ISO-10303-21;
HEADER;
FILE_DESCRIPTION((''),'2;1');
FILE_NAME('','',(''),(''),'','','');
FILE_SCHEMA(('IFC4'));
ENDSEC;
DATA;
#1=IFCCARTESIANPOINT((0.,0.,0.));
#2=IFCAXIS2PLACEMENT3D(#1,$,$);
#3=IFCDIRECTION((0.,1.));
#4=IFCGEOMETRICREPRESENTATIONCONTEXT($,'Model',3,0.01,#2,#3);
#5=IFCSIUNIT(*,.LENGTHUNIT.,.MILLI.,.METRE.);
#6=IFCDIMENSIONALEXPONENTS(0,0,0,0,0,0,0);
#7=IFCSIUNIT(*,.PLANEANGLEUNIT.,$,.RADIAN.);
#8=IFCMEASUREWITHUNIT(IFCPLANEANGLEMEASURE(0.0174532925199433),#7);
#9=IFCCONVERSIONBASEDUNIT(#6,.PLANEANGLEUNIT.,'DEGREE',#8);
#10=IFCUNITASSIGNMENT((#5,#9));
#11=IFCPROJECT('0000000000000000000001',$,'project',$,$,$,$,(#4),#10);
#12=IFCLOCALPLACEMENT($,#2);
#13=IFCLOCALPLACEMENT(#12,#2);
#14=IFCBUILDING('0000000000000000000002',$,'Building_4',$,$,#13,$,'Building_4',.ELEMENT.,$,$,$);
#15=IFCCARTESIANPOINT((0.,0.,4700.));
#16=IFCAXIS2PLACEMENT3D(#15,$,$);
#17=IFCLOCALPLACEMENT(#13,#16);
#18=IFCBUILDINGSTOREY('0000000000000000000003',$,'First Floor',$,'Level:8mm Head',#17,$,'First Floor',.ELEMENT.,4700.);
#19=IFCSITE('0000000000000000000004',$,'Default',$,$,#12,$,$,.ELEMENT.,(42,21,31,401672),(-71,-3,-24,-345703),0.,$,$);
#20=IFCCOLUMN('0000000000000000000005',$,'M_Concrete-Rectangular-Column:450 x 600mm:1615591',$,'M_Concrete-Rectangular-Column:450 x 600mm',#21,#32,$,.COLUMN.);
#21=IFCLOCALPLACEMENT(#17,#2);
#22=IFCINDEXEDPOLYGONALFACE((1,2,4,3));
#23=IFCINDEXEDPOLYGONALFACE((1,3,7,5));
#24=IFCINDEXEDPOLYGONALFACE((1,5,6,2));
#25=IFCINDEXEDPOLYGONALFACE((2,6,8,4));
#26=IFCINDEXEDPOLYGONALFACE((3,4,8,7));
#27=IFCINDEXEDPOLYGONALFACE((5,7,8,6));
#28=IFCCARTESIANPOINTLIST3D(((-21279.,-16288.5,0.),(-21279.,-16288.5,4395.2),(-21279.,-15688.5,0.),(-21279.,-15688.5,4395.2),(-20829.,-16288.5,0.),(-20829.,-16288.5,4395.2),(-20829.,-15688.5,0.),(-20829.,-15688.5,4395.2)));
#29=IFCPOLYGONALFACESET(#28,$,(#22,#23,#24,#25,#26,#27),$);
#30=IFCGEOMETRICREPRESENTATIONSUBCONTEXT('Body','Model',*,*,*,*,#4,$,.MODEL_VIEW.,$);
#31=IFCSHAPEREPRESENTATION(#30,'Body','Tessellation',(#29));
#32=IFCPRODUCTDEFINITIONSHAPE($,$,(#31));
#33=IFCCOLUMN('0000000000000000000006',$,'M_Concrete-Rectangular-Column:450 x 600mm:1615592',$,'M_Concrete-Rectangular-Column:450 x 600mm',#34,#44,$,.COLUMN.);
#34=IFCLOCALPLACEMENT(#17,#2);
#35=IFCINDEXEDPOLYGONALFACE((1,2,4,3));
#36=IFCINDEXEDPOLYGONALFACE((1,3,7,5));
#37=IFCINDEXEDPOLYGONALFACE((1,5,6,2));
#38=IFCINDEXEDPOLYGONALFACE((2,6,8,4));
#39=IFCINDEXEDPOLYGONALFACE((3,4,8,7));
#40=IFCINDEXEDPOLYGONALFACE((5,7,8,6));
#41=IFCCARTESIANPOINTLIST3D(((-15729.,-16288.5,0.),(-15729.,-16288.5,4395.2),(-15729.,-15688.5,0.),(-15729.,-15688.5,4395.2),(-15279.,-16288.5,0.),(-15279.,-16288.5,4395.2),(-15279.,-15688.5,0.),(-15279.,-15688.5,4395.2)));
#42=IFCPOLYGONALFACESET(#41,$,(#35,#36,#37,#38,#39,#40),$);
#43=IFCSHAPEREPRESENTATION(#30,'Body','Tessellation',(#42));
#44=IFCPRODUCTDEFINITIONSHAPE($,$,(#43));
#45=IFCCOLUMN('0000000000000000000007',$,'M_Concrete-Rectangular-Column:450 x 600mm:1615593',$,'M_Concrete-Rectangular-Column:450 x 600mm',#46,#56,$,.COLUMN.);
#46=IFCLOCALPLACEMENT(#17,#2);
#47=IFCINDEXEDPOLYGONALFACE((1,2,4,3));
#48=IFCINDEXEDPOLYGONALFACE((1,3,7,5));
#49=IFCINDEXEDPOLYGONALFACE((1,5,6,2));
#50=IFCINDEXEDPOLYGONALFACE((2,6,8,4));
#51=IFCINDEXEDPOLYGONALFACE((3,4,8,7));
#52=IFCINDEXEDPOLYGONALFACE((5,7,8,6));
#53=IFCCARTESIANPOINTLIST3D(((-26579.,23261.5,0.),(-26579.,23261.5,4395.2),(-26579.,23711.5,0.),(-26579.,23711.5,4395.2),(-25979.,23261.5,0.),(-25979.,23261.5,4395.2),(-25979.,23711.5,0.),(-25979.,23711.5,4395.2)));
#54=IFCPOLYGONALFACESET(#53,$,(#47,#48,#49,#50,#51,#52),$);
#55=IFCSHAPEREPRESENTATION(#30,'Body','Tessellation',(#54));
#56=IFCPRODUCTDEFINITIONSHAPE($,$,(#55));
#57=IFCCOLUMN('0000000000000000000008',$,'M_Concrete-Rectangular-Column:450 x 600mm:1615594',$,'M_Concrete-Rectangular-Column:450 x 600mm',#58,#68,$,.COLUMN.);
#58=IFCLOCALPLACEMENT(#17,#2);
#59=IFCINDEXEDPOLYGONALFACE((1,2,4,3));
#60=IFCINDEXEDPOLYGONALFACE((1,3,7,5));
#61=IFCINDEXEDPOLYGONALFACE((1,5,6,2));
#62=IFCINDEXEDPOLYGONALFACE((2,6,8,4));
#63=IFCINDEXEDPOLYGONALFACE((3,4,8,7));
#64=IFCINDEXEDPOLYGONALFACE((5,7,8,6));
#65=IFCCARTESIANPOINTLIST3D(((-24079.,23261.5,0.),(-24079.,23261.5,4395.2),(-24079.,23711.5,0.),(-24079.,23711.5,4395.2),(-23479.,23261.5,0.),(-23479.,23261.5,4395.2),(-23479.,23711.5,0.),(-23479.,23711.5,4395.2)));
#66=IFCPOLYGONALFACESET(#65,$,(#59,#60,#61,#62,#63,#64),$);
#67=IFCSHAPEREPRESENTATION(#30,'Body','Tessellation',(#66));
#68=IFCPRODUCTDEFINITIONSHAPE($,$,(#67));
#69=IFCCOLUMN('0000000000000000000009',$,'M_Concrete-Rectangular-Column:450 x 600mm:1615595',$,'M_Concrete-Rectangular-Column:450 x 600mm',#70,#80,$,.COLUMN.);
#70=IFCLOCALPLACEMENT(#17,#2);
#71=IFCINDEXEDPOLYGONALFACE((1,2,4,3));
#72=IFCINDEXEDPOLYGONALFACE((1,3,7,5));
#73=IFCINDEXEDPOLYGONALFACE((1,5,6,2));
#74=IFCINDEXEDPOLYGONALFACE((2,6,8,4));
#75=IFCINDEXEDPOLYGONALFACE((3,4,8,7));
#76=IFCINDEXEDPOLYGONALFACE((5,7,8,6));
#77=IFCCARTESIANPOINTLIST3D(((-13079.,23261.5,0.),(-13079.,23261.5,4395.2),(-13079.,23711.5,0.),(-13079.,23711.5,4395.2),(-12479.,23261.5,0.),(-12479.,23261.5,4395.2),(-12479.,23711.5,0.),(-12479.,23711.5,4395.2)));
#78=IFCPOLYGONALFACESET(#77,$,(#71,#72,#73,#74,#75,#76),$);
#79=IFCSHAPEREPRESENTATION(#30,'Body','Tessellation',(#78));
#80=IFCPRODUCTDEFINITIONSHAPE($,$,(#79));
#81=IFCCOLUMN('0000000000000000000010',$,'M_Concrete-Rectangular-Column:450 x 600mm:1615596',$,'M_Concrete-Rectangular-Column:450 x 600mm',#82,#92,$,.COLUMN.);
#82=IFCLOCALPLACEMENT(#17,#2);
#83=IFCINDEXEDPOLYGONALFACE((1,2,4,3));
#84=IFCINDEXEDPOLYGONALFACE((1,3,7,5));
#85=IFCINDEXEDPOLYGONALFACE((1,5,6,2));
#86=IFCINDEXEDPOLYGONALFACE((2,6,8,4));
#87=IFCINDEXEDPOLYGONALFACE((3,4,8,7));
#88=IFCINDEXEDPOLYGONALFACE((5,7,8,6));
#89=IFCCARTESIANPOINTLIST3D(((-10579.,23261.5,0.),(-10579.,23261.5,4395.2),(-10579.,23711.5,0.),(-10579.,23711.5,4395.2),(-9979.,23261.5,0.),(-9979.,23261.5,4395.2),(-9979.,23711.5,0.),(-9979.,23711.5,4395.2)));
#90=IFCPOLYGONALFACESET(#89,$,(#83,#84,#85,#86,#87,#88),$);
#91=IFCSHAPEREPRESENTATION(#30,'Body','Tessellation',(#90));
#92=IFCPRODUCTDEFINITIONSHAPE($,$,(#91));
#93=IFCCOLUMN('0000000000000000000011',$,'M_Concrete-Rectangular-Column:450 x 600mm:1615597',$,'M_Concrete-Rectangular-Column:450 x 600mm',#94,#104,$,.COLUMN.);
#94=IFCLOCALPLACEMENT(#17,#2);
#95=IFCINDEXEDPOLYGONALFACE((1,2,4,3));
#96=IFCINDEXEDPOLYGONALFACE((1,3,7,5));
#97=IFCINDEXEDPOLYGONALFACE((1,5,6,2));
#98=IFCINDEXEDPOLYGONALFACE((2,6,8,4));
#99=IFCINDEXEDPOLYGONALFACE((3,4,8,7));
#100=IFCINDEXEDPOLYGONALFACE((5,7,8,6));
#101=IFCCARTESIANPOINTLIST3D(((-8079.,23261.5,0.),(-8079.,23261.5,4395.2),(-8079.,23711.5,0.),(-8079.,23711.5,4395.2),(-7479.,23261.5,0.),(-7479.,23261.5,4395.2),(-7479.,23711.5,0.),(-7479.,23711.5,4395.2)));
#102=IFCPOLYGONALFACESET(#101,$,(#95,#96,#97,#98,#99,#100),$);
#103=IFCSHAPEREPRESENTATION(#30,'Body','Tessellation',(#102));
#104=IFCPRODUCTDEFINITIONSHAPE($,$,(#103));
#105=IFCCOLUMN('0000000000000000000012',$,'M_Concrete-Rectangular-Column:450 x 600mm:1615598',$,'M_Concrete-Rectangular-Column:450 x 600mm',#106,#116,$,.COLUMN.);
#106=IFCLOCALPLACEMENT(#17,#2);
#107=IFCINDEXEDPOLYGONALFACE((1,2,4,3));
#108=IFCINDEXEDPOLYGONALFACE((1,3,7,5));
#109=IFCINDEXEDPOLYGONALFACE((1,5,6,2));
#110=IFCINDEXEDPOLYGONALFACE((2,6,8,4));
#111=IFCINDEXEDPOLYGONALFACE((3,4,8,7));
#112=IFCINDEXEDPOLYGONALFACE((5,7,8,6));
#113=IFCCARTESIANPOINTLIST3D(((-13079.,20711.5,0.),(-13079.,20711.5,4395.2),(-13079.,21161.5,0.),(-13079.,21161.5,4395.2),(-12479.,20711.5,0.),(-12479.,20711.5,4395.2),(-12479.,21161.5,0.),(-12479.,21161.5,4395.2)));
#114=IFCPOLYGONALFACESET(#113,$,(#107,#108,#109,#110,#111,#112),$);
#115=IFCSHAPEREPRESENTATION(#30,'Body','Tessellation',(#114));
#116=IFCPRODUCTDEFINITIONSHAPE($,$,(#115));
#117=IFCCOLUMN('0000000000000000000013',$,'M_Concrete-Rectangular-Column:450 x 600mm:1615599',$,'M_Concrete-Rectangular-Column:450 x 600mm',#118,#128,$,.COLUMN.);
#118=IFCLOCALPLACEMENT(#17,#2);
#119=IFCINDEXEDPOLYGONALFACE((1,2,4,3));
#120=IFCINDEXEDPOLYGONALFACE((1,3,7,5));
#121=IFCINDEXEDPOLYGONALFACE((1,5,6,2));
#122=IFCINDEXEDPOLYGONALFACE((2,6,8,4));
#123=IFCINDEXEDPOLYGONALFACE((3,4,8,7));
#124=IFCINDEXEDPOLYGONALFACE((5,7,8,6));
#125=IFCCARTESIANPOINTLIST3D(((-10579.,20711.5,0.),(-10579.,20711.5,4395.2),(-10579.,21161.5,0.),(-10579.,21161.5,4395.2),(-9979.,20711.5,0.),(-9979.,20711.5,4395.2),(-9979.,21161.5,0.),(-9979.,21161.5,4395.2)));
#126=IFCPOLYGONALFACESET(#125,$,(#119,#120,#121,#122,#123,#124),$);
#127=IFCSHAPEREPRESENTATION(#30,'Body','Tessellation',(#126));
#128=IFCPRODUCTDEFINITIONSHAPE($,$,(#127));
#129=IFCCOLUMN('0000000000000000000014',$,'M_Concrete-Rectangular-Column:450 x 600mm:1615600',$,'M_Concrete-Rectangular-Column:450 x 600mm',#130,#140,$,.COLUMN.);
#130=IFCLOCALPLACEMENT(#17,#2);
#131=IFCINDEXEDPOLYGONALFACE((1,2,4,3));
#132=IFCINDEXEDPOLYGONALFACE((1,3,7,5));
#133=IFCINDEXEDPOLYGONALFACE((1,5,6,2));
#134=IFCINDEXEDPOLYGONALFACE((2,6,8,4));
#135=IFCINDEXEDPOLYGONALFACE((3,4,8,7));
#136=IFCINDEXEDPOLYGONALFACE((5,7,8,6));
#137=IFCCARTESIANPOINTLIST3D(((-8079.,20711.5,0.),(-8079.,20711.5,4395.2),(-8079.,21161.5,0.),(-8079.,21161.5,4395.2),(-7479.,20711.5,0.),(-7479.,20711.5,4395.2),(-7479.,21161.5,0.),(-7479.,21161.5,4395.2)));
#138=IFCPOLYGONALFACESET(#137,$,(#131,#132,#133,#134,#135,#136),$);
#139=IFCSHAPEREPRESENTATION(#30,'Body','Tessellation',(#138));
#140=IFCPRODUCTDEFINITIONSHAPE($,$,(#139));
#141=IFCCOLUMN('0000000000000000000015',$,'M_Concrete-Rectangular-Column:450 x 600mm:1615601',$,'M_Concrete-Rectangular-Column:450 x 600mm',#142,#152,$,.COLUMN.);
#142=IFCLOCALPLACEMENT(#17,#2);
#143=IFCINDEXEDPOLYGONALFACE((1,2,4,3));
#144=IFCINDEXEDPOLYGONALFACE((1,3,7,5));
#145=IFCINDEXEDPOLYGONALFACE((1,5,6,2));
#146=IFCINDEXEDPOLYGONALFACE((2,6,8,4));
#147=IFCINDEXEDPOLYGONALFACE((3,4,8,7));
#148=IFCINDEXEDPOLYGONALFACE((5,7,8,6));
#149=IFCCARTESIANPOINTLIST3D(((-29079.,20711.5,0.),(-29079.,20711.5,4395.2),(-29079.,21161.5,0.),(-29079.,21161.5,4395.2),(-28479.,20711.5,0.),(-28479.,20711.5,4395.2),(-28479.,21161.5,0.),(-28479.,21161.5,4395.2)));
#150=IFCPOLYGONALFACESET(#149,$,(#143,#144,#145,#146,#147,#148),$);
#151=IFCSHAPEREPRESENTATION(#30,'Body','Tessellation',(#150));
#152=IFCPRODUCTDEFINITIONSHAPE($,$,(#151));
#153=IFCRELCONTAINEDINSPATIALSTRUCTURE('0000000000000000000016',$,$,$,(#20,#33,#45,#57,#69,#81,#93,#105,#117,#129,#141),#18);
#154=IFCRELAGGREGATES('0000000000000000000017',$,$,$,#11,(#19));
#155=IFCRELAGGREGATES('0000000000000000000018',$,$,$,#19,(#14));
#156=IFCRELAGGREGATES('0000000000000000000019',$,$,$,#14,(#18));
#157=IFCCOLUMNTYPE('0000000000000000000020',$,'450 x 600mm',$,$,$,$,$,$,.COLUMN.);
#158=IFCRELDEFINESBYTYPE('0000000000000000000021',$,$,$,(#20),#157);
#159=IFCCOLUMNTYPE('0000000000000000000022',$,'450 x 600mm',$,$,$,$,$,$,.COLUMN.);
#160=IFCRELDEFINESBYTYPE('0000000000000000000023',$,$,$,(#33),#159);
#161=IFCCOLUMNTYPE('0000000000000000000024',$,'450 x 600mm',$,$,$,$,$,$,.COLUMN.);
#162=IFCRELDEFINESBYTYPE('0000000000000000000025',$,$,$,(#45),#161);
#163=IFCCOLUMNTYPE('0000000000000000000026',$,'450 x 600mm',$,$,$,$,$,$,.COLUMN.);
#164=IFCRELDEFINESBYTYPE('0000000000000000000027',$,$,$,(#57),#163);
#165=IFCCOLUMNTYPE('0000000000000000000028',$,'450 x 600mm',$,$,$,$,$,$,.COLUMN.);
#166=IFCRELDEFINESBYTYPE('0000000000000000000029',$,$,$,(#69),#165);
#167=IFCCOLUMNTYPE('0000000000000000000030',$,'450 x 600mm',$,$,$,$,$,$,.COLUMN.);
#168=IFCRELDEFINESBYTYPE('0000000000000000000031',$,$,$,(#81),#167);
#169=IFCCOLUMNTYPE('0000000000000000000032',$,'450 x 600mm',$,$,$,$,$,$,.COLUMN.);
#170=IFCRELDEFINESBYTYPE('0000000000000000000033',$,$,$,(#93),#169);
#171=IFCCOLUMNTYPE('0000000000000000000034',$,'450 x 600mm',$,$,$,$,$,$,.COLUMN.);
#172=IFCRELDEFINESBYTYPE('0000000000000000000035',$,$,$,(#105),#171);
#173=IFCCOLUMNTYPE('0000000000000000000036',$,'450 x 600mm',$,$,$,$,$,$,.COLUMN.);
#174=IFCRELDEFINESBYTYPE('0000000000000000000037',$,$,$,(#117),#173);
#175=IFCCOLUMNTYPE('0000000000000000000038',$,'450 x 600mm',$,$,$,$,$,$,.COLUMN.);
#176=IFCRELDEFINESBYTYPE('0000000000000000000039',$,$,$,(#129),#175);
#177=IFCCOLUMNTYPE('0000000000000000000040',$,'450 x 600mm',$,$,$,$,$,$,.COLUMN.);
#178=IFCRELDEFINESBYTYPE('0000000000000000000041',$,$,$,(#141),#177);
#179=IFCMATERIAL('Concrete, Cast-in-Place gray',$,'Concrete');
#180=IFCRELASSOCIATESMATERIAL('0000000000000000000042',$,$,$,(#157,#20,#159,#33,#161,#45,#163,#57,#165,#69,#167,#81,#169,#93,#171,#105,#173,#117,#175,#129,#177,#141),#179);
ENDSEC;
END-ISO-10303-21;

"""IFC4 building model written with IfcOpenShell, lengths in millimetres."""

from ifc_helpers import new_model, entity, si_unit, converted_unit, direction, frame, origin, place, context, subcontext, project, spatial, indexed_curve, outline, extrude, source, transform, mapped, material, type_object, type_shapes, element, save


model = new_model("IFC4")

# Units and contexts
model_context = context("Model", 3, precision=0.01, world=origin(), true_north=direction((0.0, 1.0)))
body_context = subcontext(model_context, "Body", "Model", "MODEL_VIEW")
ifc_project = project(units=[si_unit("LENGTHUNIT", "METRE", prefix="MILLI"), converted_unit("PLANEANGLEUNIT", "DEGREE", entity("IfcPlaneAngleMeasure", 0.0174532925199433), si_unit("PLANEANGLEUNIT", "RADIAN"), dimensions=[0, 0, 0, 0, 0, 0, 0])], contexts=[model_context])

# Site, building, storey
site_placement = place(None, origin())
site = spatial("IfcSite", under=ifc_project, at=site_placement, Name="Default", CompositionType="ELEMENT", RefLatitude=(42, 21, 31, 401672), RefLongitude=(-71, -3, -24, -345703), RefElevation=0.0)
building_placement = place(site_placement, origin())
building = spatial("IfcBuilding", under=site, at=building_placement, Name="Building_4", LongName="Building_4", CompositionType="ELEMENT")
storey_placement = place(building_placement, frame((0.0, 0.0, 4700.0)))
storey = spatial("IfcBuildingStorey", under=building, at=storey_placement, Name="First Floor", ObjectType="Level:8mm Head", LongName="First Floor", CompositionType="ELEMENT", Elevation=4700.0)

# Columns
ifc_material = material(Name="Concrete, Cast-in-Place gray", Category="Concrete")
column_type_1 = type_object("IfcColumnType", Name="450 x 600mm", PredefinedType="COLUMN", material=ifc_material)
shared_shape_1 = source(origin(), body_context, "Body", "SweptSolid", [
    extrude(outline(indexed_curve([(-2197.6, -300.0), (2197.6, -300.0), (2197.6, 300.0), (-2197.6, 300.0), (-2197.6, -300.0)], self_intersect=False)), frame((-21279.0, -15988.5, 6897.6), z_axis=(1.0, 0.0, 0.0), x_axis=(0.0, 0.0, 1.0)), (0.0, 0.0, 1.0), 450.0),
])
type_shapes(column_type_1, [shared_shape_1])
column_1_placement = place(storey_placement, frame((0.0, 0.0, -4700.0)))
element("IfcColumn", 1, at=column_1_placement, inside=storey, type_object=column_type_1, material=ifc_material, Name="M_Concrete-Rectangular-Column:450 x 600mm:1615591", ObjectType="M_Concrete-Rectangular-Column:450 x 600mm", PredefinedType="COLUMN", context=body_context, shape_type="MappedRepresentation", body=[
    mapped(shared_shape_1, transform((0.0, 0.0, 0.0), scale=1.0)),
])
column_type_2 = type_object("IfcColumnType", Name="450 x 600mm", PredefinedType="COLUMN", material=ifc_material)
shared_shape_2 = source(origin(), body_context, "Body", "SweptSolid", [
    extrude(outline(indexed_curve([(-2197.6, -300.0), (2197.6, -300.0), (2197.6, 300.0), (-2197.6, 300.0), (-2197.6, -300.0)], self_intersect=False)), frame((-15729.0, -15988.5, 6897.6), z_axis=(1.0, 0.0, 0.0), x_axis=(0.0, 0.0, 1.0)), (0.0, 0.0, 1.0), 450.0),
])
type_shapes(column_type_2, [shared_shape_2])
column_2_placement = place(storey_placement, frame((0.0, 0.0, -4700.0)))
element("IfcColumn", 2, at=column_2_placement, inside=storey, type_object=column_type_2, material=ifc_material, Name="M_Concrete-Rectangular-Column:450 x 600mm:1615592", ObjectType="M_Concrete-Rectangular-Column:450 x 600mm", PredefinedType="COLUMN", context=body_context, shape_type="MappedRepresentation", body=[
    mapped(shared_shape_2, transform((0.0, 0.0, 0.0), scale=1.0)),
])
column_type_3 = type_object("IfcColumnType", Name="450 x 600mm", PredefinedType="COLUMN", material=ifc_material)
shared_shape_3 = source(origin(), body_context, "Body", "SweptSolid", [
    extrude(outline(indexed_curve([(-225.0, -300.0), (225.0, -300.0), (225.0, 300.0), (-225.0, 300.0), (-225.0, -300.0)], self_intersect=False)), frame((-26279.0, 23486.5, 4700.0), z_axis=(0.0, 0.0, 1.0), x_axis=(0.0, -1.0, 0.0)), (0.0, 0.0, 1.0), 4395.2),
])
type_shapes(column_type_3, [shared_shape_3])
column_3_placement = place(storey_placement, frame((0.0, 0.0, -4700.0)))
element("IfcColumn", 3, at=column_3_placement, inside=storey, type_object=column_type_3, material=ifc_material, Name="M_Concrete-Rectangular-Column:450 x 600mm:1615593", ObjectType="M_Concrete-Rectangular-Column:450 x 600mm", PredefinedType="COLUMN", context=body_context, shape_type="MappedRepresentation", body=[
    mapped(shared_shape_3, transform((0.0, 0.0, 0.0), scale=1.0)),
])
column_type_4 = type_object("IfcColumnType", Name="450 x 600mm", PredefinedType="COLUMN", material=ifc_material)
shared_shape_4 = source(origin(), body_context, "Body", "SweptSolid", [
    extrude(outline(indexed_curve([(-225.0, -300.0), (225.0, -300.0), (225.0, 300.0), (-225.0, 300.0), (-225.0, -300.0)], self_intersect=False)), frame((-23779.0, 23486.5, 4700.0), z_axis=(0.0, 0.0, 1.0), x_axis=(0.0, -1.0, 0.0)), (0.0, 0.0, 1.0), 4395.2),
])
type_shapes(column_type_4, [shared_shape_4])
column_4_placement = place(storey_placement, frame((0.0, 0.0, -4700.0)))
element("IfcColumn", 4, at=column_4_placement, inside=storey, type_object=column_type_4, material=ifc_material, Name="M_Concrete-Rectangular-Column:450 x 600mm:1615594", ObjectType="M_Concrete-Rectangular-Column:450 x 600mm", PredefinedType="COLUMN", context=body_context, shape_type="MappedRepresentation", body=[
    mapped(shared_shape_4, transform((0.0, 0.0, 0.0), scale=1.0)),
])
column_type_5 = type_object("IfcColumnType", Name="450 x 600mm", PredefinedType="COLUMN", material=ifc_material)
shared_shape_5 = source(origin(), body_context, "Body", "SweptSolid", [
    extrude(outline(indexed_curve([(-2197.6, -225.0), (2197.6, -225.0), (2197.6, 225.0), (-2197.6, 225.0), (-2197.6, -225.0)], self_intersect=False)), frame((-13079.0, 23486.5, 6897.6), z_axis=(1.0, 0.0, 0.0), x_axis=(0.0, 0.0, 1.0)), (0.0, 0.0, 1.0), 600.0),
])
type_shapes(column_type_5, [shared_shape_5])
column_5_placement = place(storey_placement, frame((0.0, 0.0, -4700.0)))
element("IfcColumn", 5, at=column_5_placement, inside=storey, type_object=column_type_5, material=ifc_material, Name="M_Concrete-Rectangular-Column:450 x 600mm:1615595", ObjectType="M_Concrete-Rectangular-Column:450 x 600mm", PredefinedType="COLUMN", context=body_context, shape_type="MappedRepresentation", body=[
    mapped(shared_shape_5, transform((0.0, 0.0, 0.0), scale=1.0)),
])
column_type_6 = type_object("IfcColumnType", Name="450 x 600mm", PredefinedType="COLUMN", material=ifc_material)
shared_shape_6 = source(origin(), body_context, "Body", "SweptSolid", [
    extrude(outline(indexed_curve([(-225.0, -300.0), (225.0, -300.0), (225.0, 300.0), (-225.0, 300.0), (-225.0, -300.0)], self_intersect=False)), frame((-10279.0, 23486.5, 4700.0), z_axis=(0.0, 0.0, 1.0), x_axis=(0.0, -1.0, 0.0)), (0.0, 0.0, 1.0), 4395.2),
])
type_shapes(column_type_6, [shared_shape_6])
column_6_placement = place(storey_placement, frame((0.0, 0.0, -4700.0)))
element("IfcColumn", 6, at=column_6_placement, inside=storey, type_object=column_type_6, material=ifc_material, Name="M_Concrete-Rectangular-Column:450 x 600mm:1615596", ObjectType="M_Concrete-Rectangular-Column:450 x 600mm", PredefinedType="COLUMN", context=body_context, shape_type="MappedRepresentation", body=[
    mapped(shared_shape_6, transform((0.0, 0.0, 0.0), scale=1.0)),
])
column_type_7 = type_object("IfcColumnType", Name="450 x 600mm", PredefinedType="COLUMN", material=ifc_material)
shared_shape_7 = source(origin(), body_context, "Body", "SweptSolid", [
    extrude(outline(indexed_curve([(-225.0, -300.0), (225.0, -300.0), (225.0, 300.0), (-225.0, 300.0), (-225.0, -300.0)], self_intersect=False)), frame((-7779.0, 23486.5, 4700.0), z_axis=(0.0, 0.0, 1.0), x_axis=(0.0, -1.0, 0.0)), (0.0, 0.0, 1.0), 4395.2),
])
type_shapes(column_type_7, [shared_shape_7])
column_7_placement = place(storey_placement, frame((0.0, 0.0, -4700.0)))
element("IfcColumn", 7, at=column_7_placement, inside=storey, type_object=column_type_7, material=ifc_material, Name="M_Concrete-Rectangular-Column:450 x 600mm:1615597", ObjectType="M_Concrete-Rectangular-Column:450 x 600mm", PredefinedType="COLUMN", context=body_context, shape_type="MappedRepresentation", body=[
    mapped(shared_shape_7, transform((0.0, 0.0, 0.0), scale=1.0)),
])
column_type_8 = type_object("IfcColumnType", Name="450 x 600mm", PredefinedType="COLUMN", material=ifc_material)
shared_shape_8 = source(origin(), body_context, "Body", "SweptSolid", [
    extrude(outline(indexed_curve([(-2197.6, -225.0), (2197.6, -225.0), (2197.6, 225.0), (-2197.6, 225.0), (-2197.6, -225.0)], self_intersect=False)), frame((-13079.0, 20936.5, 6897.6), z_axis=(1.0, 0.0, 0.0), x_axis=(0.0, 0.0, 1.0)), (0.0, 0.0, 1.0), 600.0),
])
type_shapes(column_type_8, [shared_shape_8])
column_8_placement = place(storey_placement, frame((0.0, 0.0, -4700.0)))
element("IfcColumn", 8, at=column_8_placement, inside=storey, type_object=column_type_8, material=ifc_material, Name="M_Concrete-Rectangular-Column:450 x 600mm:1615598", ObjectType="M_Concrete-Rectangular-Column:450 x 600mm", PredefinedType="COLUMN", context=body_context, shape_type="MappedRepresentation", body=[
    mapped(shared_shape_8, transform((0.0, 0.0, 0.0), scale=1.0)),
])
column_type_9 = type_object("IfcColumnType", Name="450 x 600mm", PredefinedType="COLUMN", material=ifc_material)
shared_shape_9 = source(origin(), body_context, "Body", "SweptSolid", [
    extrude(outline(indexed_curve([(-225.0, -300.0), (225.0, -300.0), (225.0, 300.0), (-225.0, 300.0), (-225.0, -300.0)], self_intersect=False)), frame((-10279.0, 20936.5, 4700.0), z_axis=(0.0, 0.0, 1.0), x_axis=(0.0, -1.0, 0.0)), (0.0, 0.0, 1.0), 4395.2),
])
type_shapes(column_type_9, [shared_shape_9])
column_9_placement = place(storey_placement, frame((0.0, 0.0, -4700.0)))
element("IfcColumn", 9, at=column_9_placement, inside=storey, type_object=column_type_9, material=ifc_material, Name="M_Concrete-Rectangular-Column:450 x 600mm:1615599", ObjectType="M_Concrete-Rectangular-Column:450 x 600mm", PredefinedType="COLUMN", context=body_context, shape_type="MappedRepresentation", body=[
    mapped(shared_shape_9, transform((0.0, 0.0, 0.0), scale=1.0)),
])
column_type_10 = type_object("IfcColumnType", Name="450 x 600mm", PredefinedType="COLUMN", material=ifc_material)
shared_shape_10 = source(origin(), body_context, "Body", "SweptSolid", [
    extrude(outline(indexed_curve([(-225.0, -300.0), (225.0, -300.0), (225.0, 300.0), (-225.0, 300.0), (-225.0, -300.0)], self_intersect=False)), frame((-7779.0, 20936.5, 4700.0), z_axis=(0.0, 0.0, 1.0), x_axis=(0.0, -1.0, 0.0)), (0.0, 0.0, 1.0), 4395.2),
])
type_shapes(column_type_10, [shared_shape_10])
column_10_placement = place(storey_placement, frame((0.0, 0.0, -4700.0)))
element("IfcColumn", 10, at=column_10_placement, inside=storey, type_object=column_type_10, material=ifc_material, Name="M_Concrete-Rectangular-Column:450 x 600mm:1615600", ObjectType="M_Concrete-Rectangular-Column:450 x 600mm", PredefinedType="COLUMN", context=body_context, shape_type="MappedRepresentation", body=[
    mapped(shared_shape_10, transform((0.0, 0.0, 0.0), scale=1.0)),
])
column_type_11 = type_object("IfcColumnType", Name="450 x 600mm", PredefinedType="COLUMN", material=ifc_material)
shared_shape_11 = source(origin(), body_context, "Body", "SweptSolid", [
    extrude(outline(indexed_curve([(-225.0, -300.0), (225.0, -300.0), (225.0, 300.0), (-225.0, 300.0), (-225.0, -300.0)], self_intersect=False)), frame((-28779.0, 20936.5, 4700.0), z_axis=(0.0, 0.0, 1.0), x_axis=(0.0, -1.0, 0.0)), (0.0, 0.0, 1.0), 4395.2),
])
type_shapes(column_type_11, [shared_shape_11])
column_11_placement = place(storey_placement, frame((0.0, 0.0, -4700.0)))
element("IfcColumn", 11, at=column_11_placement, inside=storey, type_object=column_type_11, material=ifc_material, Name="M_Concrete-Rectangular-Column:450 x 600mm:1615601", ObjectType="M_Concrete-Rectangular-Column:450 x 600mm", PredefinedType="COLUMN", context=body_context, shape_type="MappedRepresentation", body=[
    mapped(shared_shape_11, transform((0.0, 0.0, 0.0), scale=1.0)),
])

save(model, "model.ifc")
